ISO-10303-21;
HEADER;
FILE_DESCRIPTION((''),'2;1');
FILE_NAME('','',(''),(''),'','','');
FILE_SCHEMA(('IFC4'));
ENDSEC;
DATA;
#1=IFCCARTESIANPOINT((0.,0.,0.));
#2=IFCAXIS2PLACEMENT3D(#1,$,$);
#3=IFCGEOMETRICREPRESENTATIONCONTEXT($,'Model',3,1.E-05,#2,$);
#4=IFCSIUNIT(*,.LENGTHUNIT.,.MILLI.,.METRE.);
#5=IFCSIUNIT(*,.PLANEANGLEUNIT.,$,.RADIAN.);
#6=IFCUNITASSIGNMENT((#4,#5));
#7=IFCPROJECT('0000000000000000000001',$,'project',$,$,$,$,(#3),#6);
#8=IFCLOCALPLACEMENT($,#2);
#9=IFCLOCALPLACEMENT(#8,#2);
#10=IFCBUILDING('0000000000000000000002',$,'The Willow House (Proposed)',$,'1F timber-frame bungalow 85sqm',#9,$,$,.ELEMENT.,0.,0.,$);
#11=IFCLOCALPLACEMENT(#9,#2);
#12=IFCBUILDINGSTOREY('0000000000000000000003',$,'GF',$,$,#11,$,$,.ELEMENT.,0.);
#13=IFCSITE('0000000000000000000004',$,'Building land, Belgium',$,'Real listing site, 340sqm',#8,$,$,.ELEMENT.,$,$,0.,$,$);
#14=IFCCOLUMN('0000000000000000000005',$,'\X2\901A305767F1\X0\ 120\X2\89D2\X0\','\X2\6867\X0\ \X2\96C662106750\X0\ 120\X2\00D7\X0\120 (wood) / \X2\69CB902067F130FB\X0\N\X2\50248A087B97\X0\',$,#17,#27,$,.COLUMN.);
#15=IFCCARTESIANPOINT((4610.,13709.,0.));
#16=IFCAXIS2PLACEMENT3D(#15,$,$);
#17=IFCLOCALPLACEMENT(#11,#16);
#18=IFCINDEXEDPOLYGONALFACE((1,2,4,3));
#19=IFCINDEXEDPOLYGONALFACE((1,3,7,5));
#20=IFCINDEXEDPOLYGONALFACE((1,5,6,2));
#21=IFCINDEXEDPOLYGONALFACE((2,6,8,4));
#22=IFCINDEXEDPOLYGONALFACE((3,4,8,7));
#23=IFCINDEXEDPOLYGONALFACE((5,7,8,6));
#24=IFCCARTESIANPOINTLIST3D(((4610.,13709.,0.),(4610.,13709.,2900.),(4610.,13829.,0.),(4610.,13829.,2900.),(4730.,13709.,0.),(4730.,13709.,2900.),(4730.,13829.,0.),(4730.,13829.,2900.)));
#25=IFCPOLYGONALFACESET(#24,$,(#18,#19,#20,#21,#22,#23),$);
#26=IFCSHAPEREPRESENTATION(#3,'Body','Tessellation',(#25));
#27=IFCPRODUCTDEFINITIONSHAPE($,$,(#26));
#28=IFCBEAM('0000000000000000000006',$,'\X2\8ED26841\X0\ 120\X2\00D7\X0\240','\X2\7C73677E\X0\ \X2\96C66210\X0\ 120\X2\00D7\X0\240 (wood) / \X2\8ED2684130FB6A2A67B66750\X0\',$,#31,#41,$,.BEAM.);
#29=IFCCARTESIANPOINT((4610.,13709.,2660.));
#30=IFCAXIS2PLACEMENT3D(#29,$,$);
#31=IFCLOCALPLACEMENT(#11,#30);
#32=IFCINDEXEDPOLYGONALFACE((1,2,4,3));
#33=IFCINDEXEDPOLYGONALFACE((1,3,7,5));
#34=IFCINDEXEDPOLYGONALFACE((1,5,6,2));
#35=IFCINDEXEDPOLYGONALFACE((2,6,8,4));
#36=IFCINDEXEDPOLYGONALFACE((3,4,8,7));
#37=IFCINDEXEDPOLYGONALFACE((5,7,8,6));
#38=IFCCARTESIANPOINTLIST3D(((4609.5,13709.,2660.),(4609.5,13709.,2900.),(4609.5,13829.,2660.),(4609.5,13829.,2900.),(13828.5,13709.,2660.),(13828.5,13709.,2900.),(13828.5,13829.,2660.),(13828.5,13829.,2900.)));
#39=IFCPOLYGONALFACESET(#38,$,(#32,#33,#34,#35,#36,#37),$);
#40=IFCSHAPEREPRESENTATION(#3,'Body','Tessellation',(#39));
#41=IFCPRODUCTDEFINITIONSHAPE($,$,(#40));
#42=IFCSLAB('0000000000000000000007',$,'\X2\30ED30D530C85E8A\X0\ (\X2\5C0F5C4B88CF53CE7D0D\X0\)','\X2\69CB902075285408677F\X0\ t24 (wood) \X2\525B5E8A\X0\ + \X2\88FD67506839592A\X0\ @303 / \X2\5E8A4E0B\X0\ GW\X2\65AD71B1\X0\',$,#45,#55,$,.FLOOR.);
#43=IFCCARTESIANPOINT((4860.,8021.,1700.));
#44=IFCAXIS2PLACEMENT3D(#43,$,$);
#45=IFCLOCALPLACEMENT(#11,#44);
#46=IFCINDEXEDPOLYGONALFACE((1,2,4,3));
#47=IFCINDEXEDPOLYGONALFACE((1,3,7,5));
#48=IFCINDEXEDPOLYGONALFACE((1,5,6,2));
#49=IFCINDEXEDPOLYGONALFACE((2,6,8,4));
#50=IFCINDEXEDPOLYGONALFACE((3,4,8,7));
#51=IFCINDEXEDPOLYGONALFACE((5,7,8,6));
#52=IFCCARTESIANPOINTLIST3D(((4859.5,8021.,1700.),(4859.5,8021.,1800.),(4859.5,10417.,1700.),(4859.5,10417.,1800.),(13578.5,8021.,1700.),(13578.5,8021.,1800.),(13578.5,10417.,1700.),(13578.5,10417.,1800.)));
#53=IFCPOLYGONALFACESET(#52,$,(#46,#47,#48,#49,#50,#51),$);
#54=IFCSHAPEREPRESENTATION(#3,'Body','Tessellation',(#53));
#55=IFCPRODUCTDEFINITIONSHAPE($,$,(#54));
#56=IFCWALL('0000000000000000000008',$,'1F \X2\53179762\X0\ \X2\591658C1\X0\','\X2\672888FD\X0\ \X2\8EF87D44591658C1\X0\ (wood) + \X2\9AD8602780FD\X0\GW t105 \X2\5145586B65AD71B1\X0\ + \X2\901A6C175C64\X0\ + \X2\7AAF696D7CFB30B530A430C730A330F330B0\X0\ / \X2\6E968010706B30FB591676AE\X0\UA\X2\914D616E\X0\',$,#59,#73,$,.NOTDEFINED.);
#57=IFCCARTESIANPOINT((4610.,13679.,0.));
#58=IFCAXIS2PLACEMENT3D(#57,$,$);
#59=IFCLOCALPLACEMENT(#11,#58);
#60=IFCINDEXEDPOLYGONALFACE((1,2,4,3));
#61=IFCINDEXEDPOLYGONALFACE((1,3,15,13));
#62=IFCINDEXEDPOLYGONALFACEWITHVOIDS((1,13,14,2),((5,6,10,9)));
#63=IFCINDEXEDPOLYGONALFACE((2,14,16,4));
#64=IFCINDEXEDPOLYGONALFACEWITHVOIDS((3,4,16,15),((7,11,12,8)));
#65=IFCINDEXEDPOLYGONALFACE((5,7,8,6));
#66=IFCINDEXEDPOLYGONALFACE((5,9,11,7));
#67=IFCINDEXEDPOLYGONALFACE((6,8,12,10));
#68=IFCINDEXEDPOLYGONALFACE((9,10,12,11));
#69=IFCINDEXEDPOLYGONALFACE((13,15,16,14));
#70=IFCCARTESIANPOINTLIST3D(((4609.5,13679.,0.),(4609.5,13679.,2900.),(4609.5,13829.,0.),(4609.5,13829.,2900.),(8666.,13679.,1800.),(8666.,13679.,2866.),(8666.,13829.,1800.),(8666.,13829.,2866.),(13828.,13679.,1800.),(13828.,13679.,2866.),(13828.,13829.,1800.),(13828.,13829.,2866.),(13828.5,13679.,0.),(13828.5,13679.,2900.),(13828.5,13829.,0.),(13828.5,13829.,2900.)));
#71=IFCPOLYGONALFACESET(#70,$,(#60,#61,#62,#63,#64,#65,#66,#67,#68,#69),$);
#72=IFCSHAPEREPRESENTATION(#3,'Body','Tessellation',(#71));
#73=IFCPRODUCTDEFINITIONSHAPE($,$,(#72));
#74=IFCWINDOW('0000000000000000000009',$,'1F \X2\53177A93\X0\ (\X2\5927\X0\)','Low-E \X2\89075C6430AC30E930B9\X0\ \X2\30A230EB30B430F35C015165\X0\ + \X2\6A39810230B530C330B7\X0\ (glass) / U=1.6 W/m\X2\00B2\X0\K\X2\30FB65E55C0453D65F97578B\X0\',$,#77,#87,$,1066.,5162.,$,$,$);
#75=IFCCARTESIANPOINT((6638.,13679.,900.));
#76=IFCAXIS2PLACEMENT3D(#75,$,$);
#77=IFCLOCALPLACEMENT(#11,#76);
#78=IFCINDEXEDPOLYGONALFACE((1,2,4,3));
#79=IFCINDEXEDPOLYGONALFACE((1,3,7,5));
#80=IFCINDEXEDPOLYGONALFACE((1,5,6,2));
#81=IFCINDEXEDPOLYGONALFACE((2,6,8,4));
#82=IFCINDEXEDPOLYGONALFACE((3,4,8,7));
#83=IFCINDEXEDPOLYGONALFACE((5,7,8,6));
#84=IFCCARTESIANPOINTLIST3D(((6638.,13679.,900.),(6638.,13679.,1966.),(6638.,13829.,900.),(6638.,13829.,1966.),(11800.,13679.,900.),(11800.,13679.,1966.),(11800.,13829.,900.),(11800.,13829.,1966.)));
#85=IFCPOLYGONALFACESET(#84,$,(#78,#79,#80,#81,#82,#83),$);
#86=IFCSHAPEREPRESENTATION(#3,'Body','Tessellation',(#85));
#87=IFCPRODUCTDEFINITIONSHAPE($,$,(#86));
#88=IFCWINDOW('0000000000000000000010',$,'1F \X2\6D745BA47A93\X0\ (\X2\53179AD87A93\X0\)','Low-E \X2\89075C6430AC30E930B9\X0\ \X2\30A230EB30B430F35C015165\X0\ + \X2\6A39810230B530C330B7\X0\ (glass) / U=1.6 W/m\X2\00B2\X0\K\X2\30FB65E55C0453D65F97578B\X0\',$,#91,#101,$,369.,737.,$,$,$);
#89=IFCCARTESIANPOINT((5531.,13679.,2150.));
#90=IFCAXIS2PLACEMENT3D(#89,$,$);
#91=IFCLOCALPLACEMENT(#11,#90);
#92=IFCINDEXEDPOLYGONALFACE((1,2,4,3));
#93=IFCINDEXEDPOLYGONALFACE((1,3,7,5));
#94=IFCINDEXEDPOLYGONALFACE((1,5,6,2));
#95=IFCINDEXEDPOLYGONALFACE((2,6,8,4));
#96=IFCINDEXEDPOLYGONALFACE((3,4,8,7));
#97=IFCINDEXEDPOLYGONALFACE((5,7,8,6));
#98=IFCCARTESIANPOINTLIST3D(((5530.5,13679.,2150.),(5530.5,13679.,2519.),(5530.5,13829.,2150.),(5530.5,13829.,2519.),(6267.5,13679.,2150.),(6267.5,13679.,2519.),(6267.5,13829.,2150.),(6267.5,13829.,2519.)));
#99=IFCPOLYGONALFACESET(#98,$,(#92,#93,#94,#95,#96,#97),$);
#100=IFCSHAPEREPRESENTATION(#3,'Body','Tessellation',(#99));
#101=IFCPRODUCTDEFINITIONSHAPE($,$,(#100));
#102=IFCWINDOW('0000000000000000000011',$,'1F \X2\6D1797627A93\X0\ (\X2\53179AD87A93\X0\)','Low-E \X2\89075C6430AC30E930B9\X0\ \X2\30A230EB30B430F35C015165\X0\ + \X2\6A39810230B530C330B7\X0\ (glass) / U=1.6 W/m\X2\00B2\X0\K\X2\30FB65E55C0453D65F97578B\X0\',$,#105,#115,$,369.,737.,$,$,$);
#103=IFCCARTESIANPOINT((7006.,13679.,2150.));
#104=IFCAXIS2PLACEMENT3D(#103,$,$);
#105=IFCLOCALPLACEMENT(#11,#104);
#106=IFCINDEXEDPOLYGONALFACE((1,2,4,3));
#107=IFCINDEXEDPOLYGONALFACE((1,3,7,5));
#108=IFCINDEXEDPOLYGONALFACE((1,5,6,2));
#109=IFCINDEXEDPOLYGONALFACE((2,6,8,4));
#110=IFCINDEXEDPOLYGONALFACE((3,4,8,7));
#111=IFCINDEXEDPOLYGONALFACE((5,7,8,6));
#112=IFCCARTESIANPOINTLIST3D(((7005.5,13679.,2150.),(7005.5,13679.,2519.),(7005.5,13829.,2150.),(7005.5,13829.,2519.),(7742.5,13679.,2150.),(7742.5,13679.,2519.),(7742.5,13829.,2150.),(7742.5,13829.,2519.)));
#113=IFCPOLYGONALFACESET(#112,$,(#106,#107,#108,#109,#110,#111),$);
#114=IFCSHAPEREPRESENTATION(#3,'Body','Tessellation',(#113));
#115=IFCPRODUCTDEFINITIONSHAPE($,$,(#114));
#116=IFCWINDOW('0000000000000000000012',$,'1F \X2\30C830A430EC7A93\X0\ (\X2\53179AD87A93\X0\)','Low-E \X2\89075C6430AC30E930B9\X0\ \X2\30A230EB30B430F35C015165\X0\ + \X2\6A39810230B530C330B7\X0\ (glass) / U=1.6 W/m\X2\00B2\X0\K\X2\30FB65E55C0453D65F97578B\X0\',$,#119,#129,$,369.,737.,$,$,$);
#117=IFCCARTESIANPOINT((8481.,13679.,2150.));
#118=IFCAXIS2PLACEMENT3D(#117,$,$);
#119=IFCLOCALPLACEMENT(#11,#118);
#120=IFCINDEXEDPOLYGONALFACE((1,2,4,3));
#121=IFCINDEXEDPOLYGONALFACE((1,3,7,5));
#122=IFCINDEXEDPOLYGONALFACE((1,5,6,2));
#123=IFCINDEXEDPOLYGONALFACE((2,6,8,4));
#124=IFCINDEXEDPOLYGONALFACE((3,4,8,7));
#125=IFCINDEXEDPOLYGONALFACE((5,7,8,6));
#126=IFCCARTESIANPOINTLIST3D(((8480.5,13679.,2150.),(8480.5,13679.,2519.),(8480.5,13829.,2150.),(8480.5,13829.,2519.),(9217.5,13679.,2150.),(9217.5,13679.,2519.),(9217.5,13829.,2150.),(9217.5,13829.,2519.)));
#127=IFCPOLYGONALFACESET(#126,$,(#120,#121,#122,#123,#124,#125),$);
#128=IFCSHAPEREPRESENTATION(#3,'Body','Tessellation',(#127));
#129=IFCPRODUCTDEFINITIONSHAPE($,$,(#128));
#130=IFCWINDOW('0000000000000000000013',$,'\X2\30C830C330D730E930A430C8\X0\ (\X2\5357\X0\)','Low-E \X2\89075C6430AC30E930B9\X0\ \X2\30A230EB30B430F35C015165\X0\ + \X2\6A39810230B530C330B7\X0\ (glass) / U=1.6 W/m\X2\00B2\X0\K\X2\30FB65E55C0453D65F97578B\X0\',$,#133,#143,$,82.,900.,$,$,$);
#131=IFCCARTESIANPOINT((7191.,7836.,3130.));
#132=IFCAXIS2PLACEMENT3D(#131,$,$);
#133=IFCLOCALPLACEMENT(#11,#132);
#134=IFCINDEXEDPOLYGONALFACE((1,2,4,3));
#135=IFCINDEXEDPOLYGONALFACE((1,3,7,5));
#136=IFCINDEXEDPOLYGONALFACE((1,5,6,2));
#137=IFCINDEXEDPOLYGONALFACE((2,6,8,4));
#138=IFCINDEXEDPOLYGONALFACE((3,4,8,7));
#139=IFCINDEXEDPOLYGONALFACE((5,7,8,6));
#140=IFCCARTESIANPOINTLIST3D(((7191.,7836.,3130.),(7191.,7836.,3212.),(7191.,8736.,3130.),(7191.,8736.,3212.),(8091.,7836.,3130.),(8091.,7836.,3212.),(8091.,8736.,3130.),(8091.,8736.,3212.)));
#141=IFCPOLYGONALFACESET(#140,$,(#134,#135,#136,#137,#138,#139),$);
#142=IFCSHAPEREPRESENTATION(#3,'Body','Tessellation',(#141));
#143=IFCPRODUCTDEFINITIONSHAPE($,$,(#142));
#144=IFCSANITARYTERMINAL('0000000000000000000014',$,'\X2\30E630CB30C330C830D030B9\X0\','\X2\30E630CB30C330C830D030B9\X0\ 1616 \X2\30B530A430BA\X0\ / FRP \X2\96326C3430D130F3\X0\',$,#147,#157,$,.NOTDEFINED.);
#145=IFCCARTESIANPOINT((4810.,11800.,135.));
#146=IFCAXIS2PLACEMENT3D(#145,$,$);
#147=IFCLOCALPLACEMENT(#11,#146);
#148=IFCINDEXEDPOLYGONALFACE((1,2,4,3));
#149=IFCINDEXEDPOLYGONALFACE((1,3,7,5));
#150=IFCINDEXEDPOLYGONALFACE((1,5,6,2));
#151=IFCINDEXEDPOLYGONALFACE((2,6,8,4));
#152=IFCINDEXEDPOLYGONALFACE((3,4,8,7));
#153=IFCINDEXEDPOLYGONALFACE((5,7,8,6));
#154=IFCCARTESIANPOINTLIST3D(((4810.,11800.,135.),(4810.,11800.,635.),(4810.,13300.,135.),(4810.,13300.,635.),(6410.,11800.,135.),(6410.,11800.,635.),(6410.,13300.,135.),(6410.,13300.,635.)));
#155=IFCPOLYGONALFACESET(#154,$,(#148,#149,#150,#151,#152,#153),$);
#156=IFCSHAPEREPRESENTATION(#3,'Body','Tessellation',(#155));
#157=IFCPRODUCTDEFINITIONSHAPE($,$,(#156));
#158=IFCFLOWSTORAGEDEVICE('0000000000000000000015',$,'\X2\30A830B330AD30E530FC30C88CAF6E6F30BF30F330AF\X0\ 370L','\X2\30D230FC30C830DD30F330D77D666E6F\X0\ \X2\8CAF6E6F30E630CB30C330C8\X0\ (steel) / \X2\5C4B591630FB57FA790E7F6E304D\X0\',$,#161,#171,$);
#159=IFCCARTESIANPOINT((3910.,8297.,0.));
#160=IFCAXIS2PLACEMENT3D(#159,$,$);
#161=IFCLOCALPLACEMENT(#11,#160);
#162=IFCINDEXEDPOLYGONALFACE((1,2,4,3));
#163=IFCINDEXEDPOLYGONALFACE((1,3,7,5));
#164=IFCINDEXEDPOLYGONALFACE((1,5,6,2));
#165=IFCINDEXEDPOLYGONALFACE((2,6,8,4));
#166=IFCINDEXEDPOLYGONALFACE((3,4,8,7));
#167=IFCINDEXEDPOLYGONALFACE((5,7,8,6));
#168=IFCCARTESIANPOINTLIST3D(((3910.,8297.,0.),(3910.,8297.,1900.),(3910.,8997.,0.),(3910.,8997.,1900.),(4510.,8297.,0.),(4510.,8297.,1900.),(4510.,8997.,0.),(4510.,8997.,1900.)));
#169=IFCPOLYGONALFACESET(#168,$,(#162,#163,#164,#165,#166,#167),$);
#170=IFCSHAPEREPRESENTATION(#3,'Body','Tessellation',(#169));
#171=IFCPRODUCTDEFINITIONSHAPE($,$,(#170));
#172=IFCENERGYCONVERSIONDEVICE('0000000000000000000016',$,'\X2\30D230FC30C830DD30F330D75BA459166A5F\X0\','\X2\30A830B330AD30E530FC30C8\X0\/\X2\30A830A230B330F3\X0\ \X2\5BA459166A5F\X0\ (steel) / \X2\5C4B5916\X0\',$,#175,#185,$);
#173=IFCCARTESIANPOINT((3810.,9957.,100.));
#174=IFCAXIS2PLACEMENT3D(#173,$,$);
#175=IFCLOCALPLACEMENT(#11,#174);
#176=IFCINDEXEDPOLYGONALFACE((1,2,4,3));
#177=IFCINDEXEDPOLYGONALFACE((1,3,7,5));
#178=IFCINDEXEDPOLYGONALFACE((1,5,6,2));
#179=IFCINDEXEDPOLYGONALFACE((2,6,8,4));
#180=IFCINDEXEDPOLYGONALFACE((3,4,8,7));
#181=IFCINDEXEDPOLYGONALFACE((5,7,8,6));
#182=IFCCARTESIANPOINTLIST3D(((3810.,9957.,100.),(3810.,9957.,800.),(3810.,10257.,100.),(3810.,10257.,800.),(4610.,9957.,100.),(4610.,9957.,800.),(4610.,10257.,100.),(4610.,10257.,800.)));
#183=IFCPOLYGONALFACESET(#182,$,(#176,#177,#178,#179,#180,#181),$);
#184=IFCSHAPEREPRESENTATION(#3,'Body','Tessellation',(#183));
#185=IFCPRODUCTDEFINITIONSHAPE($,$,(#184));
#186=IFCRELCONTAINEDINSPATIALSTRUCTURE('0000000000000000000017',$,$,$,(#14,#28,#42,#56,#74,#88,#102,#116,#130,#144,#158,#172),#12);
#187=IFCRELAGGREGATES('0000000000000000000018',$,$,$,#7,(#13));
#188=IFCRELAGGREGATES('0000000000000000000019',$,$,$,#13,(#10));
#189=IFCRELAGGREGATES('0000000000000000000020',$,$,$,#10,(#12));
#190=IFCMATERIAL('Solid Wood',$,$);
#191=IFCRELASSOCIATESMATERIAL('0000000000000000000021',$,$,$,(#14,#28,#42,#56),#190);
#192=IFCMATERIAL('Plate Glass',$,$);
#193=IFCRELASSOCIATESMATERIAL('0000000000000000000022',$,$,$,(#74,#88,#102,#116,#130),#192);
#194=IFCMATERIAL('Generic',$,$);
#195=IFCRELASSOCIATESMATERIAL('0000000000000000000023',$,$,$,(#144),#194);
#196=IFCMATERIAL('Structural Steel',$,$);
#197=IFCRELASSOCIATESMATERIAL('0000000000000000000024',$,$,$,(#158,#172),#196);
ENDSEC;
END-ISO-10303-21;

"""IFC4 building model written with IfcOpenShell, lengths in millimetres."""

from ifc_helpers import new_model, si_unit, frame, frame_2d, origin, place, context, project, spatial, rectangle, extrude, material, element, fill, save


model = new_model("IFC4")

# Units and contexts
model_context = context("Model", 3, precision=1e-05, world=origin())
ifc_project = project(units=[si_unit("LENGTHUNIT", "METRE", prefix="MILLI"), si_unit("PLANEANGLEUNIT", "RADIAN")], contexts=[model_context])

# Site, building, storey
site_placement = place(None, origin())
site = spatial("IfcSite", under=ifc_project, at=site_placement, Name="Building land, Belgium", ObjectType="Real listing site, 340sqm", CompositionType="ELEMENT", RefElevation=0.0)
building_placement = place(site_placement, origin())
building = spatial("IfcBuilding", under=site, at=building_placement, Name="The Willow House (Proposed)", ObjectType="1F timber-frame bungalow 85sqm", CompositionType="ELEMENT", ElevationOfRefHeight=0.0, ElevationOfTerrain=0.0)
storey_placement = place(building_placement, origin())
storey = spatial("IfcBuildingStorey", under=building, at=storey_placement, Name="GF", CompositionType="ELEMENT", Elevation=0.0)

# Column
ifc_material_1 = material(Name="Solid Wood")
column_1_placement = place(storey_placement, frame((4610.0, 13709.0, 0.0)))
element("IfcColumn", 1, at=column_1_placement, inside=storey, material=ifc_material_1, Name="通し柱 120角", Description="桧 集成材 120×120 (wood) / 構造柱・N値計算", PredefinedType="COLUMN", context=model_context, shape_type="SweptSolid", body=[
    extrude(rectangle(XDim=120.0, YDim=120.0, at=frame_2d((60.0, 60.0))), frame((4610.0, 13709.0, 0.0)), (0.0, 0.0, 1.0), 2900.0),
])

# Beam
beam_1_placement = place(storey_placement, frame((4610.0, 13709.0, 2660.0)))
element("IfcBeam", 2, at=beam_1_placement, inside=storey, material=ifc_material_1, Name="軒桁 120×240", Description="米松 集成 120×240 (wood) / 軒桁・横架材", PredefinedType="BEAM", context=model_context, shape_type="SweptSolid", body=[
    extrude(rectangle(XDim=9219.0, YDim=120.0, at=frame_2d((4609.0, 60.0))), frame((4610.0, 13709.0, 2660.0)), (0.0, 0.0, 1.0), 240.0),
])

# Slab
slab_placement = place(storey_placement, frame((4860.0, 8021.0, 1700.0)))
element("IfcSlab", 3, at=slab_placement, inside=storey, material=ifc_material_1, Name="ロフト床 (小屋裏収納)", Description="構造用合板 t24 (wood) 剛床 + 製材根太 @303 / 床下 GW断熱", PredefinedType="FLOOR", context=model_context, shape_type="SweptSolid", body=[
    extrude(rectangle(XDim=8719.0, YDim=2396.0, at=frame_2d((4359.0, 1198.0))), frame((4860.0, 8021.0, 1700.0)), (0.0, 0.0, 1.0), 100.0),
])

# Wall, openings, windows
wall_1_placement = place(storey_placement, frame((4610.0, 13679.0, 0.0)))
wall_1 = element("IfcWall", 4, at=wall_1_placement, inside=storey, material=ifc_material_1, Name="1F 北面 外壁", Description="木製 軸組外壁 (wood) + 高性能GW t105 充填断熱 + 通気層 + 窯業系サイディング / 準耐火・外皮UA配慮", PredefinedType="NOTDEFINED", context=model_context, shape_type="SweptSolid", body=[
    extrude(rectangle(XDim=9219.0, YDim=150.0, at=frame_2d((4609.0, 75.0))), frame((4610.0, 13679.0, 0.0)), (0.0, 0.0, 1.0), 2900.0),
])
opening_1_placement = place(storey_placement, frame((6638.0, 13679.0, 900.0)))
opening_1 = element("IfcOpeningElement", 5, at=opening_1_placement, cuts=wall_1, PredefinedType="NOTDEFINED", context=model_context, shape_type="SweptSolid", body=[
    extrude(rectangle(XDim=5162.0, YDim=150.0, at=frame_2d((2581.0, 75.0))), frame((6638.0, 13679.0, 900.0)), (0.0, 0.0, 1.0), 1066.0),
])
opening_2_placement = place(storey_placement, frame((5531.0, 13679.0, 2150.0)))
opening_2 = element("IfcOpeningElement", 6, at=opening_2_placement, cuts=wall_1, PredefinedType="NOTDEFINED", context=model_context, shape_type="SweptSolid", body=[
    extrude(rectangle(XDim=737.0, YDim=150.0, at=frame_2d((368.0, 75.0))), frame((5531.0, 13679.0, 2150.0)), (0.0, 0.0, 1.0), 369.0),
])
opening_3_placement = place(storey_placement, frame((7006.0, 13679.0, 2150.0)))
opening_3 = element("IfcOpeningElement", 7, at=opening_3_placement, cuts=wall_1, PredefinedType="NOTDEFINED", context=model_context, shape_type="SweptSolid", body=[
    extrude(rectangle(XDim=737.0, YDim=150.0, at=frame_2d((368.0, 75.0))), frame((7006.0, 13679.0, 2150.0)), (0.0, 0.0, 1.0), 369.0),
])
opening_4_placement = place(storey_placement, frame((8481.0, 13679.0, 2150.0)))
opening_4 = element("IfcOpeningElement", 8, at=opening_4_placement, cuts=wall_1, PredefinedType="NOTDEFINED", context=model_context, shape_type="SweptSolid", body=[
    extrude(rectangle(XDim=737.0, YDim=150.0, at=frame_2d((368.0, 75.0))), frame((8481.0, 13679.0, 2150.0)), (0.0, 0.0, 1.0), 369.0),
])
ifc_material_2 = material(Name="Plate Glass")
window_1_placement = place(storey_placement, frame((6638.0, 13679.0, 900.0)))
window_1 = element("IfcWindow", 9, at=window_1_placement, inside=storey, material=ifc_material_2, Name="1F 北窓 (大)", Description="Low-E 複層ガラス アルゴン封入 + 樹脂サッシ (glass) / U=1.6 W/m²K・日射取得型", OverallHeight=1066.0, OverallWidth=5162.0, context=model_context, shape_type="SweptSolid", body=[
    extrude(rectangle(XDim=5162.0, YDim=150.0, at=frame_2d((2581.0, 75.0))), frame((6638.0, 13679.0, 900.0)), (0.0, 0.0, 1.0), 1066.0),
])
fill(opening_1, window_1)
window_2_placement = place(storey_placement, frame((5531.0, 13679.0, 2150.0)))
window_2 = element("IfcWindow", 10, at=window_2_placement, inside=storey, material=ifc_material_2, Name="1F 浴室窓 (北高窓)", Description="Low-E 複層ガラス アルゴン封入 + 樹脂サッシ (glass) / U=1.6 W/m²K・日射取得型", OverallHeight=369.0, OverallWidth=737.0, context=model_context, shape_type="SweptSolid", body=[
    extrude(rectangle(XDim=737.0, YDim=150.0, at=frame_2d((368.0, 75.0))), frame((5531.0, 13679.0, 2150.0)), (0.0, 0.0, 1.0), 369.0),
])
fill(opening_2, window_2)
window_3_placement = place(storey_placement, frame((7006.0, 13679.0, 2150.0)))
window_3 = element("IfcWindow", 11, at=window_3_placement, inside=storey, material=ifc_material_2, Name="1F 洗面窓 (北高窓)", Description="Low-E 複層ガラス アルゴン封入 + 樹脂サッシ (glass) / U=1.6 W/m²K・日射取得型", OverallHeight=369.0, OverallWidth=737.0, context=model_context, shape_type="SweptSolid", body=[
    extrude(rectangle(XDim=737.0, YDim=150.0, at=frame_2d((368.0, 75.0))), frame((7006.0, 13679.0, 2150.0)), (0.0, 0.0, 1.0), 369.0),
])
fill(opening_3, window_3)
window_4_placement = place(storey_placement, frame((8481.0, 13679.0, 2150.0)))
window_4 = element("IfcWindow", 12, at=window_4_placement, inside=storey, material=ifc_material_2, Name="1F トイレ窓 (北高窓)", Description="Low-E 複層ガラス アルゴン封入 + 樹脂サッシ (glass) / U=1.6 W/m²K・日射取得型", OverallHeight=369.0, OverallWidth=737.0, context=model_context, shape_type="SweptSolid", body=[
    extrude(rectangle(XDim=737.0, YDim=150.0, at=frame_2d((368.0, 75.0))), frame((8481.0, 13679.0, 2150.0)), (0.0, 0.0, 1.0), 369.0),
])
fill(opening_4, window_4)

# Window
window_5_placement = place(storey_placement, frame((7191.0, 7836.0, 3130.0)))
element("IfcWindow", 13, at=window_5_placement, inside=storey, material=ifc_material_2, Name="トップライト (南)", Description="Low-E 複層ガラス アルゴン封入 + 樹脂サッシ (glass) / U=1.6 W/m²K・日射取得型", OverallHeight=82.0, OverallWidth=900.0, context=model_context, shape_type="SweptSolid", body=[
    extrude(rectangle(XDim=900.0, YDim=900.0, at=frame_2d((450.0, 450.0))), frame((7191.0, 7836.0, 3130.0)), (0.0, 0.0, 1.0), 82.0),
])

# Sanitary terminal
ifc_material_3 = material(Name="Generic")
sanitary_terminal_placement = place(storey_placement, frame((4810.0, 11800.0, 135.0)))
element("IfcSanitaryTerminal", 14, at=sanitary_terminal_placement, inside=storey, material=ifc_material_3, Name="ユニットバス", Description="ユニットバス 1616 サイズ / FRP 防水パン", PredefinedType="NOTDEFINED", context=model_context, shape_type="SweptSolid", body=[
    extrude(rectangle(XDim=1600.0, YDim=1500.0, at=frame_2d((800.0, 750.0))), frame((4810.0, 11800.0, 135.0)), (0.0, 0.0, 1.0), 500.0),
])

# Flow storage device
ifc_material_4 = material(Name="Structural Steel")
flow_storage_device_placement = place(storey_placement, frame((3910.0, 8297.0, 0.0)))
element("IfcFlowStorageDevice", 15, at=flow_storage_device_placement, inside=storey, material=ifc_material_4, Name="エコキュート貯湯タンク 370L", Description="ヒートポンプ給湯 貯湯ユニット (steel) / 屋外・基礎置き", context=model_context, shape_type="SweptSolid", body=[
    extrude(rectangle(XDim=600.0, YDim=700.0, at=frame_2d((300.0, 350.0))), frame((3910.0, 8297.0, 0.0)), (0.0, 0.0, 1.0), 1900.0),
])

# Energy conversion device
energy_conversion_device_placement = place(storey_placement, frame((3810.0, 9957.0, 100.0)))
element("IfcEnergyConversionDevice", 16, at=energy_conversion_device_placement, inside=storey, material=ifc_material_4, Name="ヒートポンプ室外機", Description="エコキュート/エアコン 室外機 (steel) / 屋外", context=model_context, shape_type="SweptSolid", body=[
    extrude(rectangle(XDim=800.0, YDim=300.0, at=frame_2d((400.0, 150.0))), frame((3810.0, 9957.0, 100.0)), (0.0, 0.0, 1.0), 700.0),
])

save(model, "model.ifc")
